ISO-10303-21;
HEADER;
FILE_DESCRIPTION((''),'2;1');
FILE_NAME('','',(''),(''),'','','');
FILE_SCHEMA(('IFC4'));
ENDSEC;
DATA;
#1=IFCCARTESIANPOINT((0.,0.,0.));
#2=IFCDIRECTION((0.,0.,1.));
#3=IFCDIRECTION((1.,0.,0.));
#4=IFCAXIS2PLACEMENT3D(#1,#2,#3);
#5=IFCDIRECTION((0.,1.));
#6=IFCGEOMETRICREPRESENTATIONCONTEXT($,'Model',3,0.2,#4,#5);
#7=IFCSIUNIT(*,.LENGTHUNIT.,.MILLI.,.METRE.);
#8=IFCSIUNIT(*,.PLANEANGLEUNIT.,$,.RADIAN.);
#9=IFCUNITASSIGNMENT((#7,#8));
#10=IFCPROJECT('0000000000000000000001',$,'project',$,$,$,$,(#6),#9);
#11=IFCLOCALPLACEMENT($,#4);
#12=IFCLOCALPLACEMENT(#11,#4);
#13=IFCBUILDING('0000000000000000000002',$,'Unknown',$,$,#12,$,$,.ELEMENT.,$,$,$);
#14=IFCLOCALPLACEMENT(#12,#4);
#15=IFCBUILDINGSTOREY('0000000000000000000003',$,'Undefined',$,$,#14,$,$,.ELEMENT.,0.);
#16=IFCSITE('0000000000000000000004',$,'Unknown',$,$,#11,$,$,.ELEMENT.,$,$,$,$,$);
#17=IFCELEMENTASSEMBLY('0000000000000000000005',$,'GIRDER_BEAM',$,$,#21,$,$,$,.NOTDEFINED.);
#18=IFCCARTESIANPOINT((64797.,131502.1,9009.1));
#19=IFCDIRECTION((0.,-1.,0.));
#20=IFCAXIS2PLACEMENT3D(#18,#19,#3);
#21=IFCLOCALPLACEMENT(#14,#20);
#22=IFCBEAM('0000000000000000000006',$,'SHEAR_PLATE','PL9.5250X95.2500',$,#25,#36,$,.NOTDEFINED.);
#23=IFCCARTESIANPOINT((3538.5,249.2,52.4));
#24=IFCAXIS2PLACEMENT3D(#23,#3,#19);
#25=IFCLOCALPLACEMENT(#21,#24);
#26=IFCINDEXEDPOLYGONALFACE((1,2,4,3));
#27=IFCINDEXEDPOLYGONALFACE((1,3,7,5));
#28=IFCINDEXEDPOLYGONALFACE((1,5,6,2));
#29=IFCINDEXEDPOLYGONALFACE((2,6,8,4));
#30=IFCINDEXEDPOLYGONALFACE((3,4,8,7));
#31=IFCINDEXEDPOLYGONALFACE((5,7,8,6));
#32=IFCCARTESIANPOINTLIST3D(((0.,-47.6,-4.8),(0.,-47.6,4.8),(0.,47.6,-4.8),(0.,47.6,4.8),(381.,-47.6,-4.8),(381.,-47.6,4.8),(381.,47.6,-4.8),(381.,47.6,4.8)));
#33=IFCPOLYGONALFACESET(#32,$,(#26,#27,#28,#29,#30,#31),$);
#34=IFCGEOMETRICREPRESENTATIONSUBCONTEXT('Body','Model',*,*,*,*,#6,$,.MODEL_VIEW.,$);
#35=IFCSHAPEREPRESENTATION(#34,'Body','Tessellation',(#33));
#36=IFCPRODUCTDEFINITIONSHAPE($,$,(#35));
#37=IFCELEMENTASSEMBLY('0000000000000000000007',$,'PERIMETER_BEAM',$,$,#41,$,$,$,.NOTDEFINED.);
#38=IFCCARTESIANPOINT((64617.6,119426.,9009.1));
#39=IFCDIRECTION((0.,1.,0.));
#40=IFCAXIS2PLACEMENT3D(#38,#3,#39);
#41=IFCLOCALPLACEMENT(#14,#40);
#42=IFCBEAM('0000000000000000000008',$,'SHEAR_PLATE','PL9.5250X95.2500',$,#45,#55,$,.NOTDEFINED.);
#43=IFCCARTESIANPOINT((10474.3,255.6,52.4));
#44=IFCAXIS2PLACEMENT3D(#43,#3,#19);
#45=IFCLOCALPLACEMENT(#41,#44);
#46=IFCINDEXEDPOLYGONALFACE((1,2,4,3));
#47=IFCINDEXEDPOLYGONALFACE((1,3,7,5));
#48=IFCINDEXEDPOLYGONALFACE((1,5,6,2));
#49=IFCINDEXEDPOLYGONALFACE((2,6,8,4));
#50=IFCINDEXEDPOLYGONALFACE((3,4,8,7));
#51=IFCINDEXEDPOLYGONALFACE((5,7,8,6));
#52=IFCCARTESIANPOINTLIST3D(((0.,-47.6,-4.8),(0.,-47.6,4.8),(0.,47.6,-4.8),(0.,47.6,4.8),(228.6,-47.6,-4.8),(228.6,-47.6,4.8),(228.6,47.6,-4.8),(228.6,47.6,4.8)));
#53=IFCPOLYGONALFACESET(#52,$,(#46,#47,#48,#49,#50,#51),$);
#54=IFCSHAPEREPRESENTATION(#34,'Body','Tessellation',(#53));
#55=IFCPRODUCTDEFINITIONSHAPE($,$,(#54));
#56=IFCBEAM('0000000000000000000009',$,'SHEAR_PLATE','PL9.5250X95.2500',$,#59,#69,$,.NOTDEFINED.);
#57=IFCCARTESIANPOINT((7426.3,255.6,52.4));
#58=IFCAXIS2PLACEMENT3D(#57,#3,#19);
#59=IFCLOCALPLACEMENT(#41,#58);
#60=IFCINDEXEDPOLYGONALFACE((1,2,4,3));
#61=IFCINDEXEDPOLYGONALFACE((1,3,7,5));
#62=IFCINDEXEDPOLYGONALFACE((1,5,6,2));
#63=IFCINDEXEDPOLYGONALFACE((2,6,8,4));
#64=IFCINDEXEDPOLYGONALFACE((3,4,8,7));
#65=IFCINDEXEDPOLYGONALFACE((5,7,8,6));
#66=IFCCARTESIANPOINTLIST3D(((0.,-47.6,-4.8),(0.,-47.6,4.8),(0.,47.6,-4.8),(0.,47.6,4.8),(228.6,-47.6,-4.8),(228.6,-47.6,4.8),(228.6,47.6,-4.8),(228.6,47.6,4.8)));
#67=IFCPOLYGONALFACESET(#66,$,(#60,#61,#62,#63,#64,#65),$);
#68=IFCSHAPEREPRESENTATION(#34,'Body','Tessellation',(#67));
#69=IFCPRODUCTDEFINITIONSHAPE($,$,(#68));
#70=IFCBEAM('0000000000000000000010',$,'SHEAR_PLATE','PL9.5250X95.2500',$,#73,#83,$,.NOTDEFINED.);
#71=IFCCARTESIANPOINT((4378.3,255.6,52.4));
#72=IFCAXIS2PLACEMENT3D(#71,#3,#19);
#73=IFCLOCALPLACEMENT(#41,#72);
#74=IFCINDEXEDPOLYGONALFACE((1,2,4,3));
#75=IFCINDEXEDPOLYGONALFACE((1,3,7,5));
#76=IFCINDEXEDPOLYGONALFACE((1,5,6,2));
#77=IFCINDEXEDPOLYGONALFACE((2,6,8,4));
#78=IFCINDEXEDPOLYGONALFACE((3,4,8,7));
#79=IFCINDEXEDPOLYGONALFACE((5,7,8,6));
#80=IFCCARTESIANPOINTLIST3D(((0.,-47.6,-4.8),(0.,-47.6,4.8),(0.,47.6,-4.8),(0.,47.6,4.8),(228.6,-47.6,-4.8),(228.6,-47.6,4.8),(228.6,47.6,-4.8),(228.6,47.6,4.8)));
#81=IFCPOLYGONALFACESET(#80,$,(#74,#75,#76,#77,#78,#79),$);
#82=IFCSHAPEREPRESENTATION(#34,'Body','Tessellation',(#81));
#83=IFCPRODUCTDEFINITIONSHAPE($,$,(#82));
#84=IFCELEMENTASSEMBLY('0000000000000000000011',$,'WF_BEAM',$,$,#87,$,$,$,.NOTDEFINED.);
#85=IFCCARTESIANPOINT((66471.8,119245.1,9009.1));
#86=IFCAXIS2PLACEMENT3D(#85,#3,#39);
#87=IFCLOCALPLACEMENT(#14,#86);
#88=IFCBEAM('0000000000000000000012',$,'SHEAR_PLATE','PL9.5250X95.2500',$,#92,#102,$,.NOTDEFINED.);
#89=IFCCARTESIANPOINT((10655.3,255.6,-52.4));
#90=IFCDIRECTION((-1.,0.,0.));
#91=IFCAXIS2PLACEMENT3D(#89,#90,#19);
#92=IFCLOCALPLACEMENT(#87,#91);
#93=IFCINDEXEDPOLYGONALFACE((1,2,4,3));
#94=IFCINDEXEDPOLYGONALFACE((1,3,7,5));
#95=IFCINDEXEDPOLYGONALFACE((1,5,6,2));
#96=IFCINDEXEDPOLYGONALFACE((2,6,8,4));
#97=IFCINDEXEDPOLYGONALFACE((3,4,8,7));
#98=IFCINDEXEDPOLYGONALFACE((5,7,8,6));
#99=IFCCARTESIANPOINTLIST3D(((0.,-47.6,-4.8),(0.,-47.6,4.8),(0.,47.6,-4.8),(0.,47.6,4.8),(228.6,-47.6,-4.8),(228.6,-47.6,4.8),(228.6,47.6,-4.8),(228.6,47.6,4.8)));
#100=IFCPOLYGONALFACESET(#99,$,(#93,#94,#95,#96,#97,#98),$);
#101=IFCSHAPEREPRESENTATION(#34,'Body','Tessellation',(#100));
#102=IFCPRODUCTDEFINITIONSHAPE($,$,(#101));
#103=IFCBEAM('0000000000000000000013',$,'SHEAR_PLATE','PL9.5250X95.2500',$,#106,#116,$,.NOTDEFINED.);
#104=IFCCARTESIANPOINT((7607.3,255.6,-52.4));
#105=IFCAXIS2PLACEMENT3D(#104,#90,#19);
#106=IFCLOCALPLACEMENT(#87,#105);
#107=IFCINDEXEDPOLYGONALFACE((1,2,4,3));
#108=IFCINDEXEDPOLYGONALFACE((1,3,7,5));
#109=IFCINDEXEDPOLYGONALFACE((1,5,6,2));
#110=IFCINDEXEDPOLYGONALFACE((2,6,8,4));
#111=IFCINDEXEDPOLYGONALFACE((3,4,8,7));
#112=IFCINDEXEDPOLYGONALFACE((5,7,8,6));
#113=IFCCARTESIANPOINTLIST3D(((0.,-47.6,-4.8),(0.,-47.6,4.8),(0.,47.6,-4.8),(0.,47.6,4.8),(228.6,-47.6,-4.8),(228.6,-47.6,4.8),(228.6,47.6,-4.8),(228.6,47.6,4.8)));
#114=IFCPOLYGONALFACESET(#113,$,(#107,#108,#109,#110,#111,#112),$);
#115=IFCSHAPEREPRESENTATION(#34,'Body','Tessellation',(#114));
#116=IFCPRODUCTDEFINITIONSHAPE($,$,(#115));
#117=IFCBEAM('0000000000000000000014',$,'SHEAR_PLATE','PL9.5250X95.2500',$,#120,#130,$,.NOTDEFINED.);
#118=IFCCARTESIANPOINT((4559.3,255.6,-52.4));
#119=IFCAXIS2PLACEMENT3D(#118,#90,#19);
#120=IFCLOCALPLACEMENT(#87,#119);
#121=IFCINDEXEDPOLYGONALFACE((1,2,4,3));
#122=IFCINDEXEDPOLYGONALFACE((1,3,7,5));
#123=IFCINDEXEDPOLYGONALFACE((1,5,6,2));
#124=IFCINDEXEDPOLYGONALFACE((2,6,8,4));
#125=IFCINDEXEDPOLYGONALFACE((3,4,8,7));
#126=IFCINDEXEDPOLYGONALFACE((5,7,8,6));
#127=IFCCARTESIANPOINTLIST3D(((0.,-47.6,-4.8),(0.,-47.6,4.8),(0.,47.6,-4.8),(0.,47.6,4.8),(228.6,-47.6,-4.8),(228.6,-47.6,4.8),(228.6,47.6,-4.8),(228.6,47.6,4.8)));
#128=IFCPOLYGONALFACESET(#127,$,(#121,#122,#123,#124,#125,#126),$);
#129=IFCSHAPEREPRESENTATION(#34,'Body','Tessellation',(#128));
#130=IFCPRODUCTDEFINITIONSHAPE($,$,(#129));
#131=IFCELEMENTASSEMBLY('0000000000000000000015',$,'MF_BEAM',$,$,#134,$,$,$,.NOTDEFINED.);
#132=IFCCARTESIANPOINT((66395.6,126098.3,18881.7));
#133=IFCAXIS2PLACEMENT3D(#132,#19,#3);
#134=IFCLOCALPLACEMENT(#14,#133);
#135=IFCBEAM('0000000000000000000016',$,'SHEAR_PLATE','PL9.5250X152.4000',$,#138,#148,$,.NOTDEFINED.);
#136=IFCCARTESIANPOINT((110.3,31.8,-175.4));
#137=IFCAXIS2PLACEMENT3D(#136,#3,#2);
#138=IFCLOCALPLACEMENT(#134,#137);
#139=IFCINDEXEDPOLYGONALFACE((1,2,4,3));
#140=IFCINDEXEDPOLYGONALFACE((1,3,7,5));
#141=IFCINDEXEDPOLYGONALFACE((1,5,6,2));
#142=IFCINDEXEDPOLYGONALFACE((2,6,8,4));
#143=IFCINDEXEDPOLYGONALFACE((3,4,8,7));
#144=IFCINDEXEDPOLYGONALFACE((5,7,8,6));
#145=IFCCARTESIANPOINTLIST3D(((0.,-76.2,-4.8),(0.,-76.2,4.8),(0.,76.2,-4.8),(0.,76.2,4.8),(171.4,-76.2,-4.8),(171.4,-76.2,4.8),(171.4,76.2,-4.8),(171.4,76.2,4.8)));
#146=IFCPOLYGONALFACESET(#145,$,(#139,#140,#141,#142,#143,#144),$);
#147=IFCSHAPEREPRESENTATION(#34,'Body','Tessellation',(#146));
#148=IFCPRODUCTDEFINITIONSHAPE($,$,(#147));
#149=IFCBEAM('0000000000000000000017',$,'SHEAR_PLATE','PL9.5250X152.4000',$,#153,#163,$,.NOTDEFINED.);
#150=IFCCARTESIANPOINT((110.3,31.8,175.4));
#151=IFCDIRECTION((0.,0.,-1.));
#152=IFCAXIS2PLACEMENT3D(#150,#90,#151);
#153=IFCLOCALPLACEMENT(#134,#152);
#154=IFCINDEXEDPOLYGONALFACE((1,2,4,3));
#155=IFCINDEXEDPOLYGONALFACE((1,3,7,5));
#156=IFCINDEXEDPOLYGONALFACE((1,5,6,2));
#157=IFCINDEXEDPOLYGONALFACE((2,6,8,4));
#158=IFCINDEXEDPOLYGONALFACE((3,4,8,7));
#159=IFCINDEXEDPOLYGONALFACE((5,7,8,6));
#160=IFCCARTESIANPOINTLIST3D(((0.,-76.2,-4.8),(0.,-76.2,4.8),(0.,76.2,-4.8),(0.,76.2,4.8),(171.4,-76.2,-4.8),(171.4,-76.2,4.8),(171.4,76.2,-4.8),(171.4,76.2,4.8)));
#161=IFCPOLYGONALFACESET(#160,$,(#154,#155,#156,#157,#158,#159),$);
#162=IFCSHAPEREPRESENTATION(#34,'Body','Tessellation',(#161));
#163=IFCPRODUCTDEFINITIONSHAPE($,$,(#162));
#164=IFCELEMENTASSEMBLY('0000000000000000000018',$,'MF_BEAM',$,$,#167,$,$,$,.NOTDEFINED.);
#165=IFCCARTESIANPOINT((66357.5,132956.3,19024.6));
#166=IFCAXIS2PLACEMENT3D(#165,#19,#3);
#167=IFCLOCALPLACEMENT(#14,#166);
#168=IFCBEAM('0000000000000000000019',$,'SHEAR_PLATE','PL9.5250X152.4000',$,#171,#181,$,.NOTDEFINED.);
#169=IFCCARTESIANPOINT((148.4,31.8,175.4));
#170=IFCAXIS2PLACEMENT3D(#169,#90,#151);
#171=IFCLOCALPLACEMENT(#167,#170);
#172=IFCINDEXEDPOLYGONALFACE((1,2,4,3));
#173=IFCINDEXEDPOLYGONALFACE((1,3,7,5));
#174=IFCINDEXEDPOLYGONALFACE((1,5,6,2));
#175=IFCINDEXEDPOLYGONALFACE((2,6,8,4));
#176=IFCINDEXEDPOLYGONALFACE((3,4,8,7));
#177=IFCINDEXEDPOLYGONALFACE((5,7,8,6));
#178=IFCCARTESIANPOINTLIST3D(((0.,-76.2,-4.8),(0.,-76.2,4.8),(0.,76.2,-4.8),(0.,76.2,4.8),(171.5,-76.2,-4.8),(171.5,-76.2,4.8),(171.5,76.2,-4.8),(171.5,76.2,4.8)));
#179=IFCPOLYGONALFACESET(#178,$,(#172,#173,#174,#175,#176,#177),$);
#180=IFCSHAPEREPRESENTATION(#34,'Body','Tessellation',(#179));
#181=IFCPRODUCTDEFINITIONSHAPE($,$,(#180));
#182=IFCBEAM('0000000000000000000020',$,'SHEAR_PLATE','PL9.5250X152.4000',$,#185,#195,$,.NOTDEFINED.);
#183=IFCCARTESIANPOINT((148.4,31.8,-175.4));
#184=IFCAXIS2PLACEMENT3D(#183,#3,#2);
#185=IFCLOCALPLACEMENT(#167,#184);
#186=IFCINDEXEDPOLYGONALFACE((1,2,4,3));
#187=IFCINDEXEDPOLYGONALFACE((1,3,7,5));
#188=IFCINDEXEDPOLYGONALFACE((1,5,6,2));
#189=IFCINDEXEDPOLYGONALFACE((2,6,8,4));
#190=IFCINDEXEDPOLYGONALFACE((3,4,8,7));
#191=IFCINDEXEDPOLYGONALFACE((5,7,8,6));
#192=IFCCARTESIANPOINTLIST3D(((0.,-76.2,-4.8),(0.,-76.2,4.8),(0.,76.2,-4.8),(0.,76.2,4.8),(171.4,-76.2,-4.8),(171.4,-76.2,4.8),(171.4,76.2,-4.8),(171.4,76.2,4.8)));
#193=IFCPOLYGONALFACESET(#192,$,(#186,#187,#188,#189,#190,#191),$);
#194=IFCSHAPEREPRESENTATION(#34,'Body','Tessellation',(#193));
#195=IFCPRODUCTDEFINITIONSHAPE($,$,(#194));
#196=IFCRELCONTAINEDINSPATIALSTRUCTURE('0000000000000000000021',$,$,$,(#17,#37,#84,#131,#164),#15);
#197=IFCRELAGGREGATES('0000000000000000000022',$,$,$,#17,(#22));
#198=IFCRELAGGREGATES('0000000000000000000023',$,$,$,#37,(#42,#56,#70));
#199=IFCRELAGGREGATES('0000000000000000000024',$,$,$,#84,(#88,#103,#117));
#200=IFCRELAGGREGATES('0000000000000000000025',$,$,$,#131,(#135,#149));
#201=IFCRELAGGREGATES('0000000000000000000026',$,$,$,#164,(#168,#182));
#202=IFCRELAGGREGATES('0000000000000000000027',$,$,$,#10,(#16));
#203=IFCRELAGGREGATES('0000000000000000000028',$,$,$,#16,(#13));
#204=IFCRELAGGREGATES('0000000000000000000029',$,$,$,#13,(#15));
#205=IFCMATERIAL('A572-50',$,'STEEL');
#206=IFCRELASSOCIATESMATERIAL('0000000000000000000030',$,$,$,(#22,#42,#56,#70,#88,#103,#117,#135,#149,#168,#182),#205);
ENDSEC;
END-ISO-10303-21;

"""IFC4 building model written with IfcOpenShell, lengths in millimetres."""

from ifc_helpers import new_model, si_unit, direction, frame, origin_with_axes, place, context, subcontext, project, spatial, line, indexed_curve, outline, extrude, material, element, aggregate, save


model = new_model("IFC4")

# Units and contexts
model_context = context("Model", 3, precision=0.2, world=origin_with_axes(), true_north=direction((0.0, 1.0)))
body_context = subcontext(model_context, "Body", "Model", "MODEL_VIEW")
ifc_project = project(units=[si_unit("LENGTHUNIT", "METRE", prefix="MILLI"), si_unit("PLANEANGLEUNIT", "RADIAN")], contexts=[model_context])

# Site, building, storey
site_placement = place(None, origin_with_axes())
site = spatial("IfcSite", under=ifc_project, at=site_placement, Name="Unknown", CompositionType="ELEMENT")
building_placement = place(site_placement, origin_with_axes())
building = spatial("IfcBuilding", under=site, at=building_placement, Name="Unknown", CompositionType="ELEMENT")
storey_placement = place(building_placement, origin_with_axes())
storey = spatial("IfcBuildingStorey", under=building, at=storey_placement, Name="Undefined", CompositionType="ELEMENT", Elevation=0.0)

# Element assembly, beam
assembly_1_placement = place(storey_placement, frame((64797.0, 131502.1, 9009.1), z_axis=(0.0, -1.0, 0.0), x_axis=(1.0, 0.0, 0.0)))
assembly_1 = element("IfcElementAssembly", 1, at=assembly_1_placement, inside=storey, Name="GIRDER_BEAM", PredefinedType="NOTDEFINED")
ifc_material_1 = material(Name="A572-50", Category="STEEL")
beam_1_placement = place(assembly_1_placement, frame((3538.5, 249.2, 52.4), z_axis=(1.0, 0.0, 0.0), x_axis=(0.0, -1.0, 0.0)))
beam_1 = element("IfcBeam", 2, at=beam_1_placement, material=ifc_material_1, Name="SHEAR_PLATE", Description="PL9.5250X95.2500", PredefinedType="NOTDEFINED", context=body_context, shape_type="SolidModel", body=[
    extrude(outline(indexed_curve([(-4.8, -47.6), (4.8, -47.6), (4.8, 47.6), (-4.8, 47.6)], segments=[line(1, 2, 3, 4, 1)])), frame((0.0, 0.0, 0.0), z_axis=(-1.0, 0.0, 0.0), x_axis=(0.0, 0.0, 1.0)), (0.0, 0.0, -1.0), 381.0),
])
aggregate(assembly_1, [beam_1])

# Element assemblies, beams
assembly_2_placement = place(storey_placement, frame((64617.6, 119426.0, 9009.1), z_axis=(1.0, 0.0, 0.0), x_axis=(0.0, 1.0, 0.0)))
assembly_2 = element("IfcElementAssembly", 3, at=assembly_2_placement, inside=storey, Name="PERIMETER_BEAM", PredefinedType="NOTDEFINED")
beam_2_placement = place(assembly_2_placement, frame((10474.3, 255.6, 52.4), z_axis=(1.0, 0.0, 0.0), x_axis=(0.0, -1.0, 0.0)))
beam_2 = element("IfcBeam", 4, at=beam_2_placement, material=ifc_material_1, Name="SHEAR_PLATE", Description="PL9.5250X95.2500", PredefinedType="NOTDEFINED", context=body_context, shape_type="SolidModel", body=[
    extrude(outline(indexed_curve([(-4.8, -47.6), (4.8, -47.6), (4.8, 47.6), (-4.8, 47.6)], segments=[line(1, 2, 3, 4, 1)])), frame((0.0, 0.0, 0.0), z_axis=(-1.0, 0.0, 0.0), x_axis=(0.0, 0.0, 1.0)), (0.0, 0.0, -1.0), 228.6),
])
beam_3_placement = place(assembly_2_placement, frame((7426.3, 255.6, 52.4), z_axis=(1.0, 0.0, 0.0), x_axis=(0.0, -1.0, 0.0)))
beam_3 = element("IfcBeam", 5, at=beam_3_placement, material=ifc_material_1, Name="SHEAR_PLATE", Description="PL9.5250X95.2500", PredefinedType="NOTDEFINED", context=body_context, shape_type="SolidModel", body=[
    extrude(outline(indexed_curve([(-4.8, -47.6), (4.8, -47.6), (4.8, 47.6), (-4.8, 47.6)], segments=[line(1, 2, 3, 4, 1)])), frame((0.0, 0.0, 0.0), z_axis=(-1.0, 0.0, 0.0), x_axis=(0.0, 0.0, 1.0)), (0.0, 0.0, -1.0), 228.6),
])
beam_4_placement = place(assembly_2_placement, frame((4378.3, 255.6, 52.4), z_axis=(1.0, 0.0, 0.0), x_axis=(0.0, -1.0, 0.0)))
beam_4 = element("IfcBeam", 6, at=beam_4_placement, material=ifc_material_1, Name="SHEAR_PLATE", Description="PL9.5250X95.2500", PredefinedType="NOTDEFINED", context=body_context, shape_type="SolidModel", body=[
    extrude(outline(indexed_curve([(-4.8, -47.6), (4.8, -47.6), (4.8, 47.6), (-4.8, 47.6)], segments=[line(1, 2, 3, 4, 1)])), frame((0.0, 0.0, 0.0), z_axis=(-1.0, 0.0, 0.0), x_axis=(0.0, 0.0, 1.0)), (0.0, 0.0, -1.0), 228.6),
])
aggregate(assembly_2, [beam_2, beam_3, beam_4])
assembly_3_placement = place(storey_placement, frame((66471.8, 119245.1, 9009.1), z_axis=(1.0, 0.0, 0.0), x_axis=(0.0, 1.0, 0.0)))
assembly_3 = element("IfcElementAssembly", 7, at=assembly_3_placement, inside=storey, Name="WF_BEAM", PredefinedType="NOTDEFINED")
beam_5_placement = place(assembly_3_placement, frame((10655.3, 255.6, -52.4), z_axis=(-1.0, 0.0, 0.0), x_axis=(0.0, -1.0, 0.0)))
beam_5 = element("IfcBeam", 8, at=beam_5_placement, material=ifc_material_1, Name="SHEAR_PLATE", Description="PL9.5250X95.2500", PredefinedType="NOTDEFINED", context=body_context, shape_type="SolidModel", body=[
    extrude(outline(indexed_curve([(-4.8, -47.6), (4.8, -47.6), (4.8, 47.6), (-4.8, 47.6)], segments=[line(1, 2, 3, 4, 1)])), frame((0.0, 0.0, 0.0), z_axis=(-1.0, 0.0, 0.0), x_axis=(0.0, 0.0, 1.0)), (0.0, 0.0, -1.0), 228.6),
])
beam_6_placement = place(assembly_3_placement, frame((7607.3, 255.6, -52.4), z_axis=(-1.0, 0.0, 0.0), x_axis=(0.0, -1.0, 0.0)))
beam_6 = element("IfcBeam", 9, at=beam_6_placement, material=ifc_material_1, Name="SHEAR_PLATE", Description="PL9.5250X95.2500", PredefinedType="NOTDEFINED", context=body_context, shape_type="SolidModel", body=[
    extrude(outline(indexed_curve([(-4.8, -47.6), (4.8, -47.6), (4.8, 47.6), (-4.8, 47.6)], segments=[line(1, 2, 3, 4, 1)])), frame((0.0, 0.0, 0.0), z_axis=(-1.0, 0.0, 0.0), x_axis=(0.0, 0.0, 1.0)), (0.0, 0.0, -1.0), 228.6),
])
beam_7_placement = place(assembly_3_placement, frame((4559.3, 255.6, -52.4), z_axis=(-1.0, 0.0, 0.0), x_axis=(0.0, -1.0, 0.0)))
beam_7 = element("IfcBeam", 10, at=beam_7_placement, material=ifc_material_1, Name="SHEAR_PLATE", Description="PL9.5250X95.2500", PredefinedType="NOTDEFINED", context=body_context, shape_type="SolidModel", body=[
    extrude(outline(indexed_curve([(-4.8, -47.6), (4.8, -47.6), (4.8, 47.6), (-4.8, 47.6)], segments=[line(1, 2, 3, 4, 1)])), frame((0.0, 0.0, 0.0), z_axis=(-1.0, 0.0, 0.0), x_axis=(0.0, 0.0, 1.0)), (0.0, 0.0, -1.0), 228.6),
])
aggregate(assembly_3, [beam_5, beam_6, beam_7])

# Element assembly, beams
assembly_4_placement = place(storey_placement, frame((66395.6, 126098.3, 18881.7), z_axis=(0.0, -1.0, 0.0), x_axis=(1.0, 0.0, 0.0)))
assembly_4 = element("IfcElementAssembly", 11, at=assembly_4_placement, inside=storey, Name="MF_BEAM", PredefinedType="NOTDEFINED")
beam_8_placement = place(assembly_4_placement, frame((110.3, 31.8, -175.4), z_axis=(1.0, 0.0, 0.0), x_axis=(0.0, 0.0, 1.0)))
beam_8 = element("IfcBeam", 12, at=beam_8_placement, material=ifc_material_1, Name="SHEAR_PLATE", Description="PL9.5250X152.4000", PredefinedType="NOTDEFINED", context=body_context, shape_type="SolidModel", body=[
    extrude(outline(indexed_curve([(-4.8, -76.2), (4.8, -76.2), (4.8, 76.2), (-4.8, 76.2)], segments=[line(1, 2, 3, 4, 1)])), frame((0.0, 0.0, 0.0), z_axis=(-1.0, 0.0, 0.0), x_axis=(0.0, 0.0, 1.0)), (0.0, 0.0, -1.0), 171.4),
])
beam_9_placement = place(assembly_4_placement, frame((110.3, 31.8, 175.4), z_axis=(-1.0, 0.0, 0.0), x_axis=(0.0, 0.0, -1.0)))
beam_9 = element("IfcBeam", 13, at=beam_9_placement, material=ifc_material_1, Name="SHEAR_PLATE", Description="PL9.5250X152.4000", PredefinedType="NOTDEFINED", context=body_context, shape_type="SolidModel", body=[
    extrude(outline(indexed_curve([(-4.8, -76.2), (4.8, -76.2), (4.8, 76.2), (-4.8, 76.2)], segments=[line(1, 2, 3, 4, 1)])), frame((0.0, 0.0, 0.0), z_axis=(-1.0, 0.0, 0.0), x_axis=(0.0, 0.0, 1.0)), (0.0, 0.0, -1.0), 171.4),
])
aggregate(assembly_4, [beam_8, beam_9])

# Element assembly, beams
assembly_5_placement = place(storey_placement, frame((66357.5, 132956.3, 19024.6), z_axis=(0.0, -1.0, 0.0), x_axis=(1.0, 0.0, 0.0)))
assembly_5 = element("IfcElementAssembly", 14, at=assembly_5_placement, inside=storey, Name="MF_BEAM", PredefinedType="NOTDEFINED")
beam_10_placement = place(assembly_5_placement, frame((148.4, 31.8, 175.4), z_axis=(-1.0, 0.0, 0.0), x_axis=(0.0, 0.0, -1.0)))
beam_10 = element("IfcBeam", 15, at=beam_10_placement, material=ifc_material_1, Name="SHEAR_PLATE", Description="PL9.5250X152.4000", PredefinedType="NOTDEFINED", context=body_context, shape_type="SolidModel", body=[
    extrude(outline(indexed_curve([(-4.8, -76.2), (4.8, -76.2), (4.8, 76.2), (-4.8, 76.2)], segments=[line(1, 2, 3, 4, 1)])), frame((0.0, 0.0, 0.0), z_axis=(-1.0, 0.0, 0.0), x_axis=(0.0, 0.0, 1.0)), (0.0, 0.0, -1.0), 171.4),
])
beam_11_placement = place(assembly_5_placement, frame((148.4, 31.8, -175.4), z_axis=(1.0, 0.0, 0.0), x_axis=(0.0, 0.0, 1.0)))
beam_11 = element("IfcBeam", 16, at=beam_11_placement, material=ifc_material_1, Name="SHEAR_PLATE", Description="PL9.5250X152.4000", PredefinedType="NOTDEFINED", context=body_context, shape_type="SolidModel", body=[
    extrude(outline(indexed_curve([(-4.8, -76.2), (4.8, -76.2), (4.8, 76.2), (-4.8, 76.2)], segments=[line(1, 2, 3, 4, 1)])), frame((0.0, 0.0, 0.0), z_axis=(-1.0, 0.0, 0.0), x_axis=(0.0, 0.0, 1.0)), (0.0, 0.0, -1.0), 171.4),
])
aggregate(assembly_5, [beam_10, beam_11])

save(model, "model.ifc")
